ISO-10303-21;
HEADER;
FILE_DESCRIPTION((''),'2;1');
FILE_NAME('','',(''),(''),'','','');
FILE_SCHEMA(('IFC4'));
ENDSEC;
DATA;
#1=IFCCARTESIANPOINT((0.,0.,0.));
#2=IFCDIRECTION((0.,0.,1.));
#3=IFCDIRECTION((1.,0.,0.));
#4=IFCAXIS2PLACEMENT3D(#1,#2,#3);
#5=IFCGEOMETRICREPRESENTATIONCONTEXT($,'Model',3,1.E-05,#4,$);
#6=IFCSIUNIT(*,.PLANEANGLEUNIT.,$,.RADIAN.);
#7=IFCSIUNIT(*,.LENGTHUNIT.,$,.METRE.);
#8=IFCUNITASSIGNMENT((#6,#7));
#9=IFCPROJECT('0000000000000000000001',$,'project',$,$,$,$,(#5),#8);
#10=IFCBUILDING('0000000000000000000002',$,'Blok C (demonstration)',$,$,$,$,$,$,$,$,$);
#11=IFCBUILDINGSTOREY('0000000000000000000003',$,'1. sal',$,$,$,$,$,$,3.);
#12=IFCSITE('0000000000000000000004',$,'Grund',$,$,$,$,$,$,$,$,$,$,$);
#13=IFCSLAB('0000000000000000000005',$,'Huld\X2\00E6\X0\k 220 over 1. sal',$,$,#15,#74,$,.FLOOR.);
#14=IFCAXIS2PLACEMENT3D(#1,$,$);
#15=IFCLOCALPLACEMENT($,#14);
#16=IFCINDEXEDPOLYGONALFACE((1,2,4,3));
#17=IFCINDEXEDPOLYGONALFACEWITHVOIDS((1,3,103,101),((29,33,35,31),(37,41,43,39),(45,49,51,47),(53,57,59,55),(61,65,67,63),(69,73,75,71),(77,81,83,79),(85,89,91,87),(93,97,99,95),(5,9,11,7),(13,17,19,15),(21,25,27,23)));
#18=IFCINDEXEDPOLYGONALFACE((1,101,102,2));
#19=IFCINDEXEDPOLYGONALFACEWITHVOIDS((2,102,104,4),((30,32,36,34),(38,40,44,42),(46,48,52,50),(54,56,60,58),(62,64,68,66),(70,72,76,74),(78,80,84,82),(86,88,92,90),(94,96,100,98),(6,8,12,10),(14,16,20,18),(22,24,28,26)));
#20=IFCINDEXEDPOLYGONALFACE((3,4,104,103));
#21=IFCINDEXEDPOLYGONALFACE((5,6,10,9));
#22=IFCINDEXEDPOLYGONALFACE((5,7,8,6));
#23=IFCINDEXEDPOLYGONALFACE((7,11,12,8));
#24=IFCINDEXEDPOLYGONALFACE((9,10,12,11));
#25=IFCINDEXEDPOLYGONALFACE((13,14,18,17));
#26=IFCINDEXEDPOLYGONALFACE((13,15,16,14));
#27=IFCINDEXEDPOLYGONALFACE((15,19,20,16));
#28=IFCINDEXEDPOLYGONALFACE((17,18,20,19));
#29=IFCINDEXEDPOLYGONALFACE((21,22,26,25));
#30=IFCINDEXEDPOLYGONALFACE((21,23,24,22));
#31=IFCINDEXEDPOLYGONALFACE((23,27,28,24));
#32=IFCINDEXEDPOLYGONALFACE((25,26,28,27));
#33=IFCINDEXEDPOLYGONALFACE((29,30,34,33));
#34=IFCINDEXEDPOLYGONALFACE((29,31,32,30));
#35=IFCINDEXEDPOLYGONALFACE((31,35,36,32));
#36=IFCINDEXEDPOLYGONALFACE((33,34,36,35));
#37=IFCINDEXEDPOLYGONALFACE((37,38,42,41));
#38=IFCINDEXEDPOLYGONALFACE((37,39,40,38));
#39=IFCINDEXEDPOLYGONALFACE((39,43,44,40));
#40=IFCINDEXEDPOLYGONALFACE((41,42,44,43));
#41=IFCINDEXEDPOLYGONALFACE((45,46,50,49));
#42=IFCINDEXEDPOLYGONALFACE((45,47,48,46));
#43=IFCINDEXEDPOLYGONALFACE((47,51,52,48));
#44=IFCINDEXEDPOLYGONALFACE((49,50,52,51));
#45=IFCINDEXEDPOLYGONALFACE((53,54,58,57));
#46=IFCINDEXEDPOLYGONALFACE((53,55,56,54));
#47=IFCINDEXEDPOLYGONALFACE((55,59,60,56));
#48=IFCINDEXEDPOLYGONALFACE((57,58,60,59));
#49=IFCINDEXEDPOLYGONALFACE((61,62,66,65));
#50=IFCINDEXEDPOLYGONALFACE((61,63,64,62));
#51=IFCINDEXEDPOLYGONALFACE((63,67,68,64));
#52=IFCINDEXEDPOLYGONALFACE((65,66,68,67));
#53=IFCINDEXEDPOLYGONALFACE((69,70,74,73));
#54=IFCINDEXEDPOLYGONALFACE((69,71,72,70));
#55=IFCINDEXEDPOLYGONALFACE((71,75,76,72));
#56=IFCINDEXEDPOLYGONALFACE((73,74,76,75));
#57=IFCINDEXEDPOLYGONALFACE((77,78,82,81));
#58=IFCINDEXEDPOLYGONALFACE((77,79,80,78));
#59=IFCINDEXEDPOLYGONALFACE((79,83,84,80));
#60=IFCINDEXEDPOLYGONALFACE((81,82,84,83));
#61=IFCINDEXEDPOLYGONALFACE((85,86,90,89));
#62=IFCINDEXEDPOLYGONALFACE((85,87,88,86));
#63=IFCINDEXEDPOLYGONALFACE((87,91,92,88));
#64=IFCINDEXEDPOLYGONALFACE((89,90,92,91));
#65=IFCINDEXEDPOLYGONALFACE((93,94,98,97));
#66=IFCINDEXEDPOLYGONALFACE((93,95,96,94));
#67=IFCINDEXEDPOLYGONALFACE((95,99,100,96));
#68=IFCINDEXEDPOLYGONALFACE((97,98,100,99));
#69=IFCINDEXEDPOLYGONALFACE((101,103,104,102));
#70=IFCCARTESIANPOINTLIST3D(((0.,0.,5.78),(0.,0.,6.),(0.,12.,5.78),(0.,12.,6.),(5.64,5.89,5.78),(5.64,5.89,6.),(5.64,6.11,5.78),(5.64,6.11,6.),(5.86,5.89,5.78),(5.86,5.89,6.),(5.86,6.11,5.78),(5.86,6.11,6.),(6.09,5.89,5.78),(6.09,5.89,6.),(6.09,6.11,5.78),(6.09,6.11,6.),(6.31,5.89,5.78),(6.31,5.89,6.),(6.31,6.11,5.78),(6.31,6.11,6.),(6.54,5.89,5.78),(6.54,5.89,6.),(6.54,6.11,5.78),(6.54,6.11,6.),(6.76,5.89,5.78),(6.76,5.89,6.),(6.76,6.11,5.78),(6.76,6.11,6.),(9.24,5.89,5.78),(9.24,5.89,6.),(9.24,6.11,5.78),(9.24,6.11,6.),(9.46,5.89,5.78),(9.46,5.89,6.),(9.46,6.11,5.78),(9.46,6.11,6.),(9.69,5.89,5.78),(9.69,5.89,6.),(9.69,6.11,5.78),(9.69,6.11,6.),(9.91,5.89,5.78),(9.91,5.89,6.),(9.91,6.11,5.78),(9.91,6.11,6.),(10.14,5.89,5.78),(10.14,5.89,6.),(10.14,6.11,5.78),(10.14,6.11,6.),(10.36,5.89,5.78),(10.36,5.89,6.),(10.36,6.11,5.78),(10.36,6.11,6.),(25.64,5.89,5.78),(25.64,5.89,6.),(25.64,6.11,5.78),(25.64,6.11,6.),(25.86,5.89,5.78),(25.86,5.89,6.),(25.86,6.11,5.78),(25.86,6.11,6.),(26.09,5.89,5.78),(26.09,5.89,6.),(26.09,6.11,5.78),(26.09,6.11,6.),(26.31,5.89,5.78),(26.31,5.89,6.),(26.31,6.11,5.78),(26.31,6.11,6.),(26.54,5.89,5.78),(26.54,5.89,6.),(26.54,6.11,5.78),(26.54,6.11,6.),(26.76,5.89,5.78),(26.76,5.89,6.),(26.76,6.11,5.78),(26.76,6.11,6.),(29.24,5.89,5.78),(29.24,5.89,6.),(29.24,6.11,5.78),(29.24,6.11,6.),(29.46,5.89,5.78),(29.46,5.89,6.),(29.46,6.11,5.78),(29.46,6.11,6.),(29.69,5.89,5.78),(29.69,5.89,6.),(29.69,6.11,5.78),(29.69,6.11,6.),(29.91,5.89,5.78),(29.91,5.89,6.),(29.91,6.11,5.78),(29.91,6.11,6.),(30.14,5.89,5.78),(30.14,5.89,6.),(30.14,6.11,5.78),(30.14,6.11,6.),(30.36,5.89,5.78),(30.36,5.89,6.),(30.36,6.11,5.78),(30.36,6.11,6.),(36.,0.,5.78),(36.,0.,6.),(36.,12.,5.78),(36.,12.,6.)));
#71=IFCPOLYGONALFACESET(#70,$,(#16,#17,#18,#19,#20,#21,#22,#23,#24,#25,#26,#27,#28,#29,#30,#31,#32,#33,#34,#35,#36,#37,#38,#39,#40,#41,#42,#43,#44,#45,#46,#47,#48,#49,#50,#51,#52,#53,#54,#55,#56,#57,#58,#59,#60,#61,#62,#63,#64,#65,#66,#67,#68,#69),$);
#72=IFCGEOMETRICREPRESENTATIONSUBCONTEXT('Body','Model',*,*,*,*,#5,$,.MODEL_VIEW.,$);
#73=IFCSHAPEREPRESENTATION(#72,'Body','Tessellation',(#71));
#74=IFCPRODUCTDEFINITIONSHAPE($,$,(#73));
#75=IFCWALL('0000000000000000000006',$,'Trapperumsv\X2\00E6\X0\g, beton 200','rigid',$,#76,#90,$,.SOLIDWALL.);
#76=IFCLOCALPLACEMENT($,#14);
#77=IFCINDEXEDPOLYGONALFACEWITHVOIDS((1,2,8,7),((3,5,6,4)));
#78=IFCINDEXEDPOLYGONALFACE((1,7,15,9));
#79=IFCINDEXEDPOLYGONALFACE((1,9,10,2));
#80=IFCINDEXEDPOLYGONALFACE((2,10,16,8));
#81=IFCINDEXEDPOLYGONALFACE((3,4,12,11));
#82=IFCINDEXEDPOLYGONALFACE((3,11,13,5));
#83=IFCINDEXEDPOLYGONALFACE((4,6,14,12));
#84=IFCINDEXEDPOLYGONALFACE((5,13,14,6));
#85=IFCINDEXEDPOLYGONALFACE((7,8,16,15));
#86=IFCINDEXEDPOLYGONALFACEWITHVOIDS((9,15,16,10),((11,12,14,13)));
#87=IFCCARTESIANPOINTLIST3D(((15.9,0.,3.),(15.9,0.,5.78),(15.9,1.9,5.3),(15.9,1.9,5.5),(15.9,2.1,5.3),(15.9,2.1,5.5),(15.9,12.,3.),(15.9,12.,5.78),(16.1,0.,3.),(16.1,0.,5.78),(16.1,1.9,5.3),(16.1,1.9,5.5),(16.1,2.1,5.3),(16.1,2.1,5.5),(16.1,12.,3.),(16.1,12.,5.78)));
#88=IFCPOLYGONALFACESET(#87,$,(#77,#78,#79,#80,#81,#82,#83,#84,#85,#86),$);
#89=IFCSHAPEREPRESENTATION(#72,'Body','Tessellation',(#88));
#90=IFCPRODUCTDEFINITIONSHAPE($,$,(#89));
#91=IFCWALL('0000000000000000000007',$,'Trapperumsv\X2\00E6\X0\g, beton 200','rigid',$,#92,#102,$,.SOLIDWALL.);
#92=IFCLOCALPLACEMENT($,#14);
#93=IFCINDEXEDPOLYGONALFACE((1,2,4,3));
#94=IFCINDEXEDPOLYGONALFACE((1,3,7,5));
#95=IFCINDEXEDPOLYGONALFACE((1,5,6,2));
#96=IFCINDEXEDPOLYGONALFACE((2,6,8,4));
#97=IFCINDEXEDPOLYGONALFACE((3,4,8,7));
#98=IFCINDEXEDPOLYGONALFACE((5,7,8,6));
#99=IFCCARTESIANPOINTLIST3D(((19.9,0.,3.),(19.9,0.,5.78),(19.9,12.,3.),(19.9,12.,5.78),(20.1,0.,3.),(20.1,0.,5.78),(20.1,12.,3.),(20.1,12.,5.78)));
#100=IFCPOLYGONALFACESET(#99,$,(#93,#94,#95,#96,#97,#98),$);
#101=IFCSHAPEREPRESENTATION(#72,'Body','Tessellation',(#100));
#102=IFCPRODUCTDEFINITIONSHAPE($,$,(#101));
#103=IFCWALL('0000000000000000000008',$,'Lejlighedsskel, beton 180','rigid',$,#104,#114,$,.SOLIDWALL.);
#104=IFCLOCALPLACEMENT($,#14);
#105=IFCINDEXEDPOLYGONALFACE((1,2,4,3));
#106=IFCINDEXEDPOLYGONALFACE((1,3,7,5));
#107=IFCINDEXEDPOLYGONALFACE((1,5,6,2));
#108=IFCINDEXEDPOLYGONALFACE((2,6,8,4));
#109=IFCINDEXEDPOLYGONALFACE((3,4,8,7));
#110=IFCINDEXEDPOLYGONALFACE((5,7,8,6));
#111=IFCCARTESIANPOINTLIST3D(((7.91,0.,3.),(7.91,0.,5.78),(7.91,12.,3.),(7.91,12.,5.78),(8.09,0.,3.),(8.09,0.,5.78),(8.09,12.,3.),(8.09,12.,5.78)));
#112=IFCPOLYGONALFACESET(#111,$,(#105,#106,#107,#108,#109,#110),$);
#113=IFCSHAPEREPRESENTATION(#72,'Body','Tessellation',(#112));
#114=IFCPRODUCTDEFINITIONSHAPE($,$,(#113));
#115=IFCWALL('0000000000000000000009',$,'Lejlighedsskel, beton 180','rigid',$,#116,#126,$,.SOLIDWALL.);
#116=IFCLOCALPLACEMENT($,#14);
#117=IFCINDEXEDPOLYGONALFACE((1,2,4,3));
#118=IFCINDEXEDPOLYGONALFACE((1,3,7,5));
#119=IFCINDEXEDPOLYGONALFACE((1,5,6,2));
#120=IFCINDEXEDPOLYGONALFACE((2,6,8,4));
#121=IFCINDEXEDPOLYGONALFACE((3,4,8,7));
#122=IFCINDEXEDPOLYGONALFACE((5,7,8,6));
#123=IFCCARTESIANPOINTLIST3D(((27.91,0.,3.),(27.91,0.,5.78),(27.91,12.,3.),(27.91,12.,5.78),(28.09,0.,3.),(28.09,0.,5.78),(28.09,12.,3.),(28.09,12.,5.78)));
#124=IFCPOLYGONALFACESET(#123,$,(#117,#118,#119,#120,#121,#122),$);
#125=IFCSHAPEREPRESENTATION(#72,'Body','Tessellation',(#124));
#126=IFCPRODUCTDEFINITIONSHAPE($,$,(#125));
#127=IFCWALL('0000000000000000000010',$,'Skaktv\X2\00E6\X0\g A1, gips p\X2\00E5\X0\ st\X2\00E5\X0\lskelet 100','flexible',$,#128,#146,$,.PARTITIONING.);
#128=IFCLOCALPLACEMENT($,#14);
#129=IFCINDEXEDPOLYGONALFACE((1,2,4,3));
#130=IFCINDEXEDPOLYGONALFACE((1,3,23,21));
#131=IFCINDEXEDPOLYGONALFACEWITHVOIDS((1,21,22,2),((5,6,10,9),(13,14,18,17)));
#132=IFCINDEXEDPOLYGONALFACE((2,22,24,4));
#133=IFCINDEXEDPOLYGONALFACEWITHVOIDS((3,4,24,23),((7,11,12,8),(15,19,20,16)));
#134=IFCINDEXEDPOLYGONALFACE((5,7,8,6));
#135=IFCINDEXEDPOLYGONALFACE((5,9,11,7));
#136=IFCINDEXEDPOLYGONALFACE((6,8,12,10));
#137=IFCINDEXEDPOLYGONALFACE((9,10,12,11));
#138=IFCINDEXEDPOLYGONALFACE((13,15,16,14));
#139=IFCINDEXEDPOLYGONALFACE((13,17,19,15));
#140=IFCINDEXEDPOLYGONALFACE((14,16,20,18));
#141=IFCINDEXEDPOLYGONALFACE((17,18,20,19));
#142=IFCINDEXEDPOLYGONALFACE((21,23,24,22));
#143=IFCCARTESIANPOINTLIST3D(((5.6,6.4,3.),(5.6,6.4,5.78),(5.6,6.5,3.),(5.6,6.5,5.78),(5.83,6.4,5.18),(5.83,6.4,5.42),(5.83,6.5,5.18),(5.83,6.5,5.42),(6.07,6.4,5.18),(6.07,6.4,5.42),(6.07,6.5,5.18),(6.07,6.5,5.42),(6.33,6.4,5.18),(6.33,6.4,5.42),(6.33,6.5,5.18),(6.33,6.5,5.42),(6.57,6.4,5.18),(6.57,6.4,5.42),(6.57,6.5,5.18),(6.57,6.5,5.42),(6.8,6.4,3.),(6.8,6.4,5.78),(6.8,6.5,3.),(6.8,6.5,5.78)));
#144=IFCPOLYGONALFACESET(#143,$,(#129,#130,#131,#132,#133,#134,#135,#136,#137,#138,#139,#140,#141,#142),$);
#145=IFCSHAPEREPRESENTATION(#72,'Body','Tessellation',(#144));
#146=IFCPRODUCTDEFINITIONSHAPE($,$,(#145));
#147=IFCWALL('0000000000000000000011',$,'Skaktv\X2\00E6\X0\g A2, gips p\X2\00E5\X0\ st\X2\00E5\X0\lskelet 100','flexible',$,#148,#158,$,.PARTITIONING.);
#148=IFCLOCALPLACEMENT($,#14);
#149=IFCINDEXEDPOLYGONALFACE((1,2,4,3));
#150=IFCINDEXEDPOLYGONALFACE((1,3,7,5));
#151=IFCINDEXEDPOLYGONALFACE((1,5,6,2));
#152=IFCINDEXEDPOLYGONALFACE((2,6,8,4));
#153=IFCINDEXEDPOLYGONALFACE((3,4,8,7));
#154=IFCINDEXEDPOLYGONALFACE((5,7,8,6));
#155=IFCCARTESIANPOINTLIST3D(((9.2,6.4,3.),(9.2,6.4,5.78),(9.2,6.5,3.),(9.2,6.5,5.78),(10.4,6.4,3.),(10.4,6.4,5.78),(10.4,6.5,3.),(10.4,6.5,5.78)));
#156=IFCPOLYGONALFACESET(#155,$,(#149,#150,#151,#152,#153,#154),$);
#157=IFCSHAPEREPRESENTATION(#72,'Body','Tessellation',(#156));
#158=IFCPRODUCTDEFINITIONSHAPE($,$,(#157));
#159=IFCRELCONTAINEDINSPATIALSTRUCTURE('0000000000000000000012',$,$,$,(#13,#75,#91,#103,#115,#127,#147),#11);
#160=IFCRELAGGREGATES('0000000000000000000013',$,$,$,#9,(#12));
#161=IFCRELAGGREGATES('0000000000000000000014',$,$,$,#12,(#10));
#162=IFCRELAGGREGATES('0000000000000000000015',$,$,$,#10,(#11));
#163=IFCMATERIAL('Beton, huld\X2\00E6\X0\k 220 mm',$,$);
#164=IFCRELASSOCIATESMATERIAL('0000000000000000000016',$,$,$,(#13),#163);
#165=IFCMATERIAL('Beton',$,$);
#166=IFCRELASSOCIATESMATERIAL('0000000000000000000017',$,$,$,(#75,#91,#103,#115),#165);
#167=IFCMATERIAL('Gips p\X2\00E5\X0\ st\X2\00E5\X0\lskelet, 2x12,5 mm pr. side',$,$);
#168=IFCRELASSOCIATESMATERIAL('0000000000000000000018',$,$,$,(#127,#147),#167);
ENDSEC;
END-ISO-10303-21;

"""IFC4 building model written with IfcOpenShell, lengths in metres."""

from ifc_helpers import new_model, si_unit, frame, origin_with_axes, place, context, subcontext, project, spatial, polyline, outline, extrude, material, element, save


model = new_model("IFC4")

# Units and contexts
model_context = context("Model", 3, precision=1e-05, world=origin_with_axes())
body_context = subcontext(model_context, "Body", "Model", "MODEL_VIEW")
ifc_project = project(units=[si_unit("PLANEANGLEUNIT", "RADIAN"), si_unit("LENGTHUNIT", "METRE")], contexts=[model_context])

# Site, building, storey
site = spatial("IfcSite", under=ifc_project, Name="Grund")
building = spatial("IfcBuilding", under=site, Name="Blok C (demonstration)")
storey = spatial("IfcBuildingStorey", under=building, Name="1. sal", Elevation=3.0)

# Slab, openings
ifc_material_1 = material(Name="Beton, huldæk 220 mm")
slab_placement = place(None, origin_with_axes())
slab = element("IfcSlab", 1, at=slab_placement, inside=storey, material=ifc_material_1, Name="Huldæk 220 over 1. sal", PredefinedType="FLOOR", context=body_context, shape_type="SweptSolid", body=[
    extrude(outline(polyline([(0.0, 0.0), (36.0, 0.0), (36.0, 12.0), (0.0, 12.0), (0.0, 0.0)])), frame((0.0, 0.0, 5.78)), (0.0, 0.0, 1.0), 0.22),
])
opening_1_placement = place(slab_placement, origin_with_axes())
element("IfcOpeningElement", 2, at=opening_1_placement, cuts=slab, PredefinedType="OPENING", context=body_context, shape_type="SweptSolid", body=[
    extrude(outline(polyline([(5.64, 5.89), (5.86, 5.89), (5.86, 6.11), (5.64, 6.11), (5.64, 5.89)])), frame((0.0, 0.0, 5.77)), (0.0, 0.0, 1.0), 0.24),
])
opening_2_placement = place(slab_placement, origin_with_axes())
element("IfcOpeningElement", 3, at=opening_2_placement, cuts=slab, PredefinedType="OPENING", context=body_context, shape_type="SweptSolid", body=[
    extrude(outline(polyline([(6.09, 5.89), (6.31, 5.89), (6.31, 6.11), (6.09, 6.11), (6.09, 5.89)])), frame((0.0, 0.0, 5.77)), (0.0, 0.0, 1.0), 0.24),
])
opening_3_placement = place(slab_placement, origin_with_axes())
element("IfcOpeningElement", 4, at=opening_3_placement, cuts=slab, PredefinedType="OPENING", context=body_context, shape_type="SweptSolid", body=[
    extrude(outline(polyline([(6.54, 5.89), (6.76, 5.89), (6.76, 6.11), (6.54, 6.11), (6.54, 5.89)])), frame((0.0, 0.0, 5.77)), (0.0, 0.0, 1.0), 0.24),
])
opening_4_placement = place(slab_placement, origin_with_axes())
element("IfcOpeningElement", 5, at=opening_4_placement, cuts=slab, PredefinedType="OPENING", context=body_context, shape_type="SweptSolid", body=[
    extrude(outline(polyline([(9.24, 5.89), (9.46, 5.89), (9.46, 6.11), (9.24, 6.11), (9.24, 5.89)])), frame((0.0, 0.0, 5.77)), (0.0, 0.0, 1.0), 0.24),
])
opening_5_placement = place(slab_placement, origin_with_axes())
element("IfcOpeningElement", 6, at=opening_5_placement, cuts=slab, PredefinedType="OPENING", context=body_context, shape_type="SweptSolid", body=[
    extrude(outline(polyline([(9.69, 5.89), (9.91, 5.89), (9.91, 6.11), (9.69, 6.11), (9.69, 5.89)])), frame((0.0, 0.0, 5.77)), (0.0, 0.0, 1.0), 0.24),
])
opening_6_placement = place(slab_placement, origin_with_axes())
element("IfcOpeningElement", 7, at=opening_6_placement, cuts=slab, PredefinedType="OPENING", context=body_context, shape_type="SweptSolid", body=[
    extrude(outline(polyline([(10.14, 5.89), (10.36, 5.89), (10.36, 6.11), (10.14, 6.11), (10.14, 5.89)])), frame((0.0, 0.0, 5.77)), (0.0, 0.0, 1.0), 0.24),
])
opening_7_placement = place(slab_placement, origin_with_axes())
element("IfcOpeningElement", 8, at=opening_7_placement, cuts=slab, PredefinedType="OPENING", context=body_context, shape_type="SweptSolid", body=[
    extrude(outline(polyline([(25.64, 5.89), (25.86, 5.89), (25.86, 6.11), (25.64, 6.11), (25.64, 5.89)])), frame((0.0, 0.0, 5.77)), (0.0, 0.0, 1.0), 0.24),
])
opening_8_placement = place(slab_placement, origin_with_axes())
element("IfcOpeningElement", 9, at=opening_8_placement, cuts=slab, PredefinedType="OPENING", context=body_context, shape_type="SweptSolid", body=[
    extrude(outline(polyline([(26.09, 5.89), (26.31, 5.89), (26.31, 6.11), (26.09, 6.11), (26.09, 5.89)])), frame((0.0, 0.0, 5.77)), (0.0, 0.0, 1.0), 0.24),
])
opening_9_placement = place(slab_placement, origin_with_axes())
element("IfcOpeningElement", 10, at=opening_9_placement, cuts=slab, PredefinedType="OPENING", context=body_context, shape_type="SweptSolid", body=[
    extrude(outline(polyline([(26.54, 5.89), (26.76, 5.89), (26.76, 6.11), (26.54, 6.11), (26.54, 5.89)])), frame((0.0, 0.0, 5.77)), (0.0, 0.0, 1.0), 0.24),
])
opening_10_placement = place(slab_placement, origin_with_axes())
element("IfcOpeningElement", 11, at=opening_10_placement, cuts=slab, PredefinedType="OPENING", context=body_context, shape_type="SweptSolid", body=[
    extrude(outline(polyline([(29.24, 5.89), (29.46, 5.89), (29.46, 6.11), (29.24, 6.11), (29.24, 5.89)])), frame((0.0, 0.0, 5.77)), (0.0, 0.0, 1.0), 0.24),
])
opening_11_placement = place(slab_placement, origin_with_axes())
element("IfcOpeningElement", 12, at=opening_11_placement, cuts=slab, PredefinedType="OPENING", context=body_context, shape_type="SweptSolid", body=[
    extrude(outline(polyline([(29.69, 5.89), (29.91, 5.89), (29.91, 6.11), (29.69, 6.11), (29.69, 5.89)])), frame((0.0, 0.0, 5.77)), (0.0, 0.0, 1.0), 0.24),
])
opening_12_placement = place(slab_placement, origin_with_axes())
element("IfcOpeningElement", 13, at=opening_12_placement, cuts=slab, PredefinedType="OPENING", context=body_context, shape_type="SweptSolid", body=[
    extrude(outline(polyline([(30.14, 5.89), (30.36, 5.89), (30.36, 6.11), (30.14, 6.11), (30.14, 5.89)])), frame((0.0, 0.0, 5.77)), (0.0, 0.0, 1.0), 0.24),
])

# Wall, opening
ifc_material_2 = material(Name="Beton")
wall_1_placement = place(None, origin_with_axes())
wall_1 = element("IfcWall", 14, at=wall_1_placement, inside=storey, material=ifc_material_2, Name="Trapperumsvæg, beton 200", Description="rigid", PredefinedType="SOLIDWALL", context=body_context, shape_type="SweptSolid", body=[
    extrude(outline(polyline([(15.9, 0.0), (16.1, 0.0), (16.1, 12.0), (15.9, 12.0), (15.9, 0.0)])), frame((0.0, 0.0, 3.0)), (0.0, 0.0, 1.0), 2.78),
])
opening_13_placement = place(wall_1_placement, origin_with_axes())
element("IfcOpeningElement", 15, at=opening_13_placement, cuts=wall_1, PredefinedType="OPENING", context=body_context, shape_type="SweptSolid", body=[
    extrude(outline(polyline([(15.88, 1.9), (16.12, 1.9), (16.12, 2.1), (15.88, 2.1), (15.88, 1.9)])), frame((0.0, 0.0, 5.3)), (0.0, 0.0, 1.0), 0.2),
])

# Walls
wall_2_placement = place(None, origin_with_axes())
element("IfcWall", 16, at=wall_2_placement, inside=storey, material=ifc_material_2, Name="Trapperumsvæg, beton 200", Description="rigid", PredefinedType="SOLIDWALL", context=body_context, shape_type="SweptSolid", body=[
    extrude(outline(polyline([(19.9, 0.0), (20.1, 0.0), (20.1, 12.0), (19.9, 12.0), (19.9, 0.0)])), frame((0.0, 0.0, 3.0)), (0.0, 0.0, 1.0), 2.78),
])
wall_3_placement = place(None, origin_with_axes())
element("IfcWall", 17, at=wall_3_placement, inside=storey, material=ifc_material_2, Name="Lejlighedsskel, beton 180", Description="rigid", PredefinedType="SOLIDWALL", context=body_context, shape_type="SweptSolid", body=[
    extrude(outline(polyline([(7.91, 0.0), (8.09, 0.0), (8.09, 12.0), (7.91, 12.0), (7.91, 0.0)])), frame((0.0, 0.0, 3.0)), (0.0, 0.0, 1.0), 2.78),
])
wall_4_placement = place(None, origin_with_axes())
element("IfcWall", 18, at=wall_4_placement, inside=storey, material=ifc_material_2, Name="Lejlighedsskel, beton 180", Description="rigid", PredefinedType="SOLIDWALL", context=body_context, shape_type="SweptSolid", body=[
    extrude(outline(polyline([(27.91, 0.0), (28.09, 0.0), (28.09, 12.0), (27.91, 12.0), (27.91, 0.0)])), frame((0.0, 0.0, 3.0)), (0.0, 0.0, 1.0), 2.78),
])

# Wall, openings
ifc_material_3 = material(Name="Gips på stålskelet, 2x12,5 mm pr. side")
wall_5_placement = place(None, origin_with_axes())
wall_5 = element("IfcWall", 19, at=wall_5_placement, inside=storey, material=ifc_material_3, Name="Skaktvæg A1, gips på stålskelet 100", Description="flexible", PredefinedType="PARTITIONING", context=body_context, shape_type="SweptSolid", body=[
    extrude(outline(polyline([(5.6, 6.4), (6.8, 6.4), (6.8, 6.5), (5.6, 6.5), (5.6, 6.4)])), frame((0.0, 0.0, 3.0)), (0.0, 0.0, 1.0), 2.78),
])
opening_14_placement = place(wall_5_placement, origin_with_axes())
element("IfcOpeningElement", 20, at=opening_14_placement, cuts=wall_5, PredefinedType="OPENING", context=body_context, shape_type="SweptSolid", body=[
    extrude(outline(polyline([(5.83, 6.33), (6.07, 6.33), (6.07, 6.57), (5.83, 6.57), (5.83, 6.33)])), frame((0.0, 0.0, 5.18)), (0.0, 0.0, 1.0), 0.24),
])
opening_15_placement = place(wall_5_placement, origin_with_axes())
element("IfcOpeningElement", 21, at=opening_15_placement, cuts=wall_5, PredefinedType="OPENING", context=body_context, shape_type="SweptSolid", body=[
    extrude(outline(polyline([(6.33, 6.33), (6.57, 6.33), (6.57, 6.57), (6.33, 6.57), (6.33, 6.33)])), frame((0.0, 0.0, 5.18)), (0.0, 0.0, 1.0), 0.24),
])

# Wall
wall_6_placement = place(None, origin_with_axes())
element("IfcWall", 22, at=wall_6_placement, inside=storey, material=ifc_material_3, Name="Skaktvæg A2, gips på stålskelet 100", Description="flexible", PredefinedType="PARTITIONING", context=body_context, shape_type="SweptSolid", body=[
    extrude(outline(polyline([(9.2, 6.4), (10.4, 6.4), (10.4, 6.5), (9.2, 6.5), (9.2, 6.4)])), frame((0.0, 0.0, 3.0)), (0.0, 0.0, 1.0), 2.78),
])

save(model, "model.ifc")
